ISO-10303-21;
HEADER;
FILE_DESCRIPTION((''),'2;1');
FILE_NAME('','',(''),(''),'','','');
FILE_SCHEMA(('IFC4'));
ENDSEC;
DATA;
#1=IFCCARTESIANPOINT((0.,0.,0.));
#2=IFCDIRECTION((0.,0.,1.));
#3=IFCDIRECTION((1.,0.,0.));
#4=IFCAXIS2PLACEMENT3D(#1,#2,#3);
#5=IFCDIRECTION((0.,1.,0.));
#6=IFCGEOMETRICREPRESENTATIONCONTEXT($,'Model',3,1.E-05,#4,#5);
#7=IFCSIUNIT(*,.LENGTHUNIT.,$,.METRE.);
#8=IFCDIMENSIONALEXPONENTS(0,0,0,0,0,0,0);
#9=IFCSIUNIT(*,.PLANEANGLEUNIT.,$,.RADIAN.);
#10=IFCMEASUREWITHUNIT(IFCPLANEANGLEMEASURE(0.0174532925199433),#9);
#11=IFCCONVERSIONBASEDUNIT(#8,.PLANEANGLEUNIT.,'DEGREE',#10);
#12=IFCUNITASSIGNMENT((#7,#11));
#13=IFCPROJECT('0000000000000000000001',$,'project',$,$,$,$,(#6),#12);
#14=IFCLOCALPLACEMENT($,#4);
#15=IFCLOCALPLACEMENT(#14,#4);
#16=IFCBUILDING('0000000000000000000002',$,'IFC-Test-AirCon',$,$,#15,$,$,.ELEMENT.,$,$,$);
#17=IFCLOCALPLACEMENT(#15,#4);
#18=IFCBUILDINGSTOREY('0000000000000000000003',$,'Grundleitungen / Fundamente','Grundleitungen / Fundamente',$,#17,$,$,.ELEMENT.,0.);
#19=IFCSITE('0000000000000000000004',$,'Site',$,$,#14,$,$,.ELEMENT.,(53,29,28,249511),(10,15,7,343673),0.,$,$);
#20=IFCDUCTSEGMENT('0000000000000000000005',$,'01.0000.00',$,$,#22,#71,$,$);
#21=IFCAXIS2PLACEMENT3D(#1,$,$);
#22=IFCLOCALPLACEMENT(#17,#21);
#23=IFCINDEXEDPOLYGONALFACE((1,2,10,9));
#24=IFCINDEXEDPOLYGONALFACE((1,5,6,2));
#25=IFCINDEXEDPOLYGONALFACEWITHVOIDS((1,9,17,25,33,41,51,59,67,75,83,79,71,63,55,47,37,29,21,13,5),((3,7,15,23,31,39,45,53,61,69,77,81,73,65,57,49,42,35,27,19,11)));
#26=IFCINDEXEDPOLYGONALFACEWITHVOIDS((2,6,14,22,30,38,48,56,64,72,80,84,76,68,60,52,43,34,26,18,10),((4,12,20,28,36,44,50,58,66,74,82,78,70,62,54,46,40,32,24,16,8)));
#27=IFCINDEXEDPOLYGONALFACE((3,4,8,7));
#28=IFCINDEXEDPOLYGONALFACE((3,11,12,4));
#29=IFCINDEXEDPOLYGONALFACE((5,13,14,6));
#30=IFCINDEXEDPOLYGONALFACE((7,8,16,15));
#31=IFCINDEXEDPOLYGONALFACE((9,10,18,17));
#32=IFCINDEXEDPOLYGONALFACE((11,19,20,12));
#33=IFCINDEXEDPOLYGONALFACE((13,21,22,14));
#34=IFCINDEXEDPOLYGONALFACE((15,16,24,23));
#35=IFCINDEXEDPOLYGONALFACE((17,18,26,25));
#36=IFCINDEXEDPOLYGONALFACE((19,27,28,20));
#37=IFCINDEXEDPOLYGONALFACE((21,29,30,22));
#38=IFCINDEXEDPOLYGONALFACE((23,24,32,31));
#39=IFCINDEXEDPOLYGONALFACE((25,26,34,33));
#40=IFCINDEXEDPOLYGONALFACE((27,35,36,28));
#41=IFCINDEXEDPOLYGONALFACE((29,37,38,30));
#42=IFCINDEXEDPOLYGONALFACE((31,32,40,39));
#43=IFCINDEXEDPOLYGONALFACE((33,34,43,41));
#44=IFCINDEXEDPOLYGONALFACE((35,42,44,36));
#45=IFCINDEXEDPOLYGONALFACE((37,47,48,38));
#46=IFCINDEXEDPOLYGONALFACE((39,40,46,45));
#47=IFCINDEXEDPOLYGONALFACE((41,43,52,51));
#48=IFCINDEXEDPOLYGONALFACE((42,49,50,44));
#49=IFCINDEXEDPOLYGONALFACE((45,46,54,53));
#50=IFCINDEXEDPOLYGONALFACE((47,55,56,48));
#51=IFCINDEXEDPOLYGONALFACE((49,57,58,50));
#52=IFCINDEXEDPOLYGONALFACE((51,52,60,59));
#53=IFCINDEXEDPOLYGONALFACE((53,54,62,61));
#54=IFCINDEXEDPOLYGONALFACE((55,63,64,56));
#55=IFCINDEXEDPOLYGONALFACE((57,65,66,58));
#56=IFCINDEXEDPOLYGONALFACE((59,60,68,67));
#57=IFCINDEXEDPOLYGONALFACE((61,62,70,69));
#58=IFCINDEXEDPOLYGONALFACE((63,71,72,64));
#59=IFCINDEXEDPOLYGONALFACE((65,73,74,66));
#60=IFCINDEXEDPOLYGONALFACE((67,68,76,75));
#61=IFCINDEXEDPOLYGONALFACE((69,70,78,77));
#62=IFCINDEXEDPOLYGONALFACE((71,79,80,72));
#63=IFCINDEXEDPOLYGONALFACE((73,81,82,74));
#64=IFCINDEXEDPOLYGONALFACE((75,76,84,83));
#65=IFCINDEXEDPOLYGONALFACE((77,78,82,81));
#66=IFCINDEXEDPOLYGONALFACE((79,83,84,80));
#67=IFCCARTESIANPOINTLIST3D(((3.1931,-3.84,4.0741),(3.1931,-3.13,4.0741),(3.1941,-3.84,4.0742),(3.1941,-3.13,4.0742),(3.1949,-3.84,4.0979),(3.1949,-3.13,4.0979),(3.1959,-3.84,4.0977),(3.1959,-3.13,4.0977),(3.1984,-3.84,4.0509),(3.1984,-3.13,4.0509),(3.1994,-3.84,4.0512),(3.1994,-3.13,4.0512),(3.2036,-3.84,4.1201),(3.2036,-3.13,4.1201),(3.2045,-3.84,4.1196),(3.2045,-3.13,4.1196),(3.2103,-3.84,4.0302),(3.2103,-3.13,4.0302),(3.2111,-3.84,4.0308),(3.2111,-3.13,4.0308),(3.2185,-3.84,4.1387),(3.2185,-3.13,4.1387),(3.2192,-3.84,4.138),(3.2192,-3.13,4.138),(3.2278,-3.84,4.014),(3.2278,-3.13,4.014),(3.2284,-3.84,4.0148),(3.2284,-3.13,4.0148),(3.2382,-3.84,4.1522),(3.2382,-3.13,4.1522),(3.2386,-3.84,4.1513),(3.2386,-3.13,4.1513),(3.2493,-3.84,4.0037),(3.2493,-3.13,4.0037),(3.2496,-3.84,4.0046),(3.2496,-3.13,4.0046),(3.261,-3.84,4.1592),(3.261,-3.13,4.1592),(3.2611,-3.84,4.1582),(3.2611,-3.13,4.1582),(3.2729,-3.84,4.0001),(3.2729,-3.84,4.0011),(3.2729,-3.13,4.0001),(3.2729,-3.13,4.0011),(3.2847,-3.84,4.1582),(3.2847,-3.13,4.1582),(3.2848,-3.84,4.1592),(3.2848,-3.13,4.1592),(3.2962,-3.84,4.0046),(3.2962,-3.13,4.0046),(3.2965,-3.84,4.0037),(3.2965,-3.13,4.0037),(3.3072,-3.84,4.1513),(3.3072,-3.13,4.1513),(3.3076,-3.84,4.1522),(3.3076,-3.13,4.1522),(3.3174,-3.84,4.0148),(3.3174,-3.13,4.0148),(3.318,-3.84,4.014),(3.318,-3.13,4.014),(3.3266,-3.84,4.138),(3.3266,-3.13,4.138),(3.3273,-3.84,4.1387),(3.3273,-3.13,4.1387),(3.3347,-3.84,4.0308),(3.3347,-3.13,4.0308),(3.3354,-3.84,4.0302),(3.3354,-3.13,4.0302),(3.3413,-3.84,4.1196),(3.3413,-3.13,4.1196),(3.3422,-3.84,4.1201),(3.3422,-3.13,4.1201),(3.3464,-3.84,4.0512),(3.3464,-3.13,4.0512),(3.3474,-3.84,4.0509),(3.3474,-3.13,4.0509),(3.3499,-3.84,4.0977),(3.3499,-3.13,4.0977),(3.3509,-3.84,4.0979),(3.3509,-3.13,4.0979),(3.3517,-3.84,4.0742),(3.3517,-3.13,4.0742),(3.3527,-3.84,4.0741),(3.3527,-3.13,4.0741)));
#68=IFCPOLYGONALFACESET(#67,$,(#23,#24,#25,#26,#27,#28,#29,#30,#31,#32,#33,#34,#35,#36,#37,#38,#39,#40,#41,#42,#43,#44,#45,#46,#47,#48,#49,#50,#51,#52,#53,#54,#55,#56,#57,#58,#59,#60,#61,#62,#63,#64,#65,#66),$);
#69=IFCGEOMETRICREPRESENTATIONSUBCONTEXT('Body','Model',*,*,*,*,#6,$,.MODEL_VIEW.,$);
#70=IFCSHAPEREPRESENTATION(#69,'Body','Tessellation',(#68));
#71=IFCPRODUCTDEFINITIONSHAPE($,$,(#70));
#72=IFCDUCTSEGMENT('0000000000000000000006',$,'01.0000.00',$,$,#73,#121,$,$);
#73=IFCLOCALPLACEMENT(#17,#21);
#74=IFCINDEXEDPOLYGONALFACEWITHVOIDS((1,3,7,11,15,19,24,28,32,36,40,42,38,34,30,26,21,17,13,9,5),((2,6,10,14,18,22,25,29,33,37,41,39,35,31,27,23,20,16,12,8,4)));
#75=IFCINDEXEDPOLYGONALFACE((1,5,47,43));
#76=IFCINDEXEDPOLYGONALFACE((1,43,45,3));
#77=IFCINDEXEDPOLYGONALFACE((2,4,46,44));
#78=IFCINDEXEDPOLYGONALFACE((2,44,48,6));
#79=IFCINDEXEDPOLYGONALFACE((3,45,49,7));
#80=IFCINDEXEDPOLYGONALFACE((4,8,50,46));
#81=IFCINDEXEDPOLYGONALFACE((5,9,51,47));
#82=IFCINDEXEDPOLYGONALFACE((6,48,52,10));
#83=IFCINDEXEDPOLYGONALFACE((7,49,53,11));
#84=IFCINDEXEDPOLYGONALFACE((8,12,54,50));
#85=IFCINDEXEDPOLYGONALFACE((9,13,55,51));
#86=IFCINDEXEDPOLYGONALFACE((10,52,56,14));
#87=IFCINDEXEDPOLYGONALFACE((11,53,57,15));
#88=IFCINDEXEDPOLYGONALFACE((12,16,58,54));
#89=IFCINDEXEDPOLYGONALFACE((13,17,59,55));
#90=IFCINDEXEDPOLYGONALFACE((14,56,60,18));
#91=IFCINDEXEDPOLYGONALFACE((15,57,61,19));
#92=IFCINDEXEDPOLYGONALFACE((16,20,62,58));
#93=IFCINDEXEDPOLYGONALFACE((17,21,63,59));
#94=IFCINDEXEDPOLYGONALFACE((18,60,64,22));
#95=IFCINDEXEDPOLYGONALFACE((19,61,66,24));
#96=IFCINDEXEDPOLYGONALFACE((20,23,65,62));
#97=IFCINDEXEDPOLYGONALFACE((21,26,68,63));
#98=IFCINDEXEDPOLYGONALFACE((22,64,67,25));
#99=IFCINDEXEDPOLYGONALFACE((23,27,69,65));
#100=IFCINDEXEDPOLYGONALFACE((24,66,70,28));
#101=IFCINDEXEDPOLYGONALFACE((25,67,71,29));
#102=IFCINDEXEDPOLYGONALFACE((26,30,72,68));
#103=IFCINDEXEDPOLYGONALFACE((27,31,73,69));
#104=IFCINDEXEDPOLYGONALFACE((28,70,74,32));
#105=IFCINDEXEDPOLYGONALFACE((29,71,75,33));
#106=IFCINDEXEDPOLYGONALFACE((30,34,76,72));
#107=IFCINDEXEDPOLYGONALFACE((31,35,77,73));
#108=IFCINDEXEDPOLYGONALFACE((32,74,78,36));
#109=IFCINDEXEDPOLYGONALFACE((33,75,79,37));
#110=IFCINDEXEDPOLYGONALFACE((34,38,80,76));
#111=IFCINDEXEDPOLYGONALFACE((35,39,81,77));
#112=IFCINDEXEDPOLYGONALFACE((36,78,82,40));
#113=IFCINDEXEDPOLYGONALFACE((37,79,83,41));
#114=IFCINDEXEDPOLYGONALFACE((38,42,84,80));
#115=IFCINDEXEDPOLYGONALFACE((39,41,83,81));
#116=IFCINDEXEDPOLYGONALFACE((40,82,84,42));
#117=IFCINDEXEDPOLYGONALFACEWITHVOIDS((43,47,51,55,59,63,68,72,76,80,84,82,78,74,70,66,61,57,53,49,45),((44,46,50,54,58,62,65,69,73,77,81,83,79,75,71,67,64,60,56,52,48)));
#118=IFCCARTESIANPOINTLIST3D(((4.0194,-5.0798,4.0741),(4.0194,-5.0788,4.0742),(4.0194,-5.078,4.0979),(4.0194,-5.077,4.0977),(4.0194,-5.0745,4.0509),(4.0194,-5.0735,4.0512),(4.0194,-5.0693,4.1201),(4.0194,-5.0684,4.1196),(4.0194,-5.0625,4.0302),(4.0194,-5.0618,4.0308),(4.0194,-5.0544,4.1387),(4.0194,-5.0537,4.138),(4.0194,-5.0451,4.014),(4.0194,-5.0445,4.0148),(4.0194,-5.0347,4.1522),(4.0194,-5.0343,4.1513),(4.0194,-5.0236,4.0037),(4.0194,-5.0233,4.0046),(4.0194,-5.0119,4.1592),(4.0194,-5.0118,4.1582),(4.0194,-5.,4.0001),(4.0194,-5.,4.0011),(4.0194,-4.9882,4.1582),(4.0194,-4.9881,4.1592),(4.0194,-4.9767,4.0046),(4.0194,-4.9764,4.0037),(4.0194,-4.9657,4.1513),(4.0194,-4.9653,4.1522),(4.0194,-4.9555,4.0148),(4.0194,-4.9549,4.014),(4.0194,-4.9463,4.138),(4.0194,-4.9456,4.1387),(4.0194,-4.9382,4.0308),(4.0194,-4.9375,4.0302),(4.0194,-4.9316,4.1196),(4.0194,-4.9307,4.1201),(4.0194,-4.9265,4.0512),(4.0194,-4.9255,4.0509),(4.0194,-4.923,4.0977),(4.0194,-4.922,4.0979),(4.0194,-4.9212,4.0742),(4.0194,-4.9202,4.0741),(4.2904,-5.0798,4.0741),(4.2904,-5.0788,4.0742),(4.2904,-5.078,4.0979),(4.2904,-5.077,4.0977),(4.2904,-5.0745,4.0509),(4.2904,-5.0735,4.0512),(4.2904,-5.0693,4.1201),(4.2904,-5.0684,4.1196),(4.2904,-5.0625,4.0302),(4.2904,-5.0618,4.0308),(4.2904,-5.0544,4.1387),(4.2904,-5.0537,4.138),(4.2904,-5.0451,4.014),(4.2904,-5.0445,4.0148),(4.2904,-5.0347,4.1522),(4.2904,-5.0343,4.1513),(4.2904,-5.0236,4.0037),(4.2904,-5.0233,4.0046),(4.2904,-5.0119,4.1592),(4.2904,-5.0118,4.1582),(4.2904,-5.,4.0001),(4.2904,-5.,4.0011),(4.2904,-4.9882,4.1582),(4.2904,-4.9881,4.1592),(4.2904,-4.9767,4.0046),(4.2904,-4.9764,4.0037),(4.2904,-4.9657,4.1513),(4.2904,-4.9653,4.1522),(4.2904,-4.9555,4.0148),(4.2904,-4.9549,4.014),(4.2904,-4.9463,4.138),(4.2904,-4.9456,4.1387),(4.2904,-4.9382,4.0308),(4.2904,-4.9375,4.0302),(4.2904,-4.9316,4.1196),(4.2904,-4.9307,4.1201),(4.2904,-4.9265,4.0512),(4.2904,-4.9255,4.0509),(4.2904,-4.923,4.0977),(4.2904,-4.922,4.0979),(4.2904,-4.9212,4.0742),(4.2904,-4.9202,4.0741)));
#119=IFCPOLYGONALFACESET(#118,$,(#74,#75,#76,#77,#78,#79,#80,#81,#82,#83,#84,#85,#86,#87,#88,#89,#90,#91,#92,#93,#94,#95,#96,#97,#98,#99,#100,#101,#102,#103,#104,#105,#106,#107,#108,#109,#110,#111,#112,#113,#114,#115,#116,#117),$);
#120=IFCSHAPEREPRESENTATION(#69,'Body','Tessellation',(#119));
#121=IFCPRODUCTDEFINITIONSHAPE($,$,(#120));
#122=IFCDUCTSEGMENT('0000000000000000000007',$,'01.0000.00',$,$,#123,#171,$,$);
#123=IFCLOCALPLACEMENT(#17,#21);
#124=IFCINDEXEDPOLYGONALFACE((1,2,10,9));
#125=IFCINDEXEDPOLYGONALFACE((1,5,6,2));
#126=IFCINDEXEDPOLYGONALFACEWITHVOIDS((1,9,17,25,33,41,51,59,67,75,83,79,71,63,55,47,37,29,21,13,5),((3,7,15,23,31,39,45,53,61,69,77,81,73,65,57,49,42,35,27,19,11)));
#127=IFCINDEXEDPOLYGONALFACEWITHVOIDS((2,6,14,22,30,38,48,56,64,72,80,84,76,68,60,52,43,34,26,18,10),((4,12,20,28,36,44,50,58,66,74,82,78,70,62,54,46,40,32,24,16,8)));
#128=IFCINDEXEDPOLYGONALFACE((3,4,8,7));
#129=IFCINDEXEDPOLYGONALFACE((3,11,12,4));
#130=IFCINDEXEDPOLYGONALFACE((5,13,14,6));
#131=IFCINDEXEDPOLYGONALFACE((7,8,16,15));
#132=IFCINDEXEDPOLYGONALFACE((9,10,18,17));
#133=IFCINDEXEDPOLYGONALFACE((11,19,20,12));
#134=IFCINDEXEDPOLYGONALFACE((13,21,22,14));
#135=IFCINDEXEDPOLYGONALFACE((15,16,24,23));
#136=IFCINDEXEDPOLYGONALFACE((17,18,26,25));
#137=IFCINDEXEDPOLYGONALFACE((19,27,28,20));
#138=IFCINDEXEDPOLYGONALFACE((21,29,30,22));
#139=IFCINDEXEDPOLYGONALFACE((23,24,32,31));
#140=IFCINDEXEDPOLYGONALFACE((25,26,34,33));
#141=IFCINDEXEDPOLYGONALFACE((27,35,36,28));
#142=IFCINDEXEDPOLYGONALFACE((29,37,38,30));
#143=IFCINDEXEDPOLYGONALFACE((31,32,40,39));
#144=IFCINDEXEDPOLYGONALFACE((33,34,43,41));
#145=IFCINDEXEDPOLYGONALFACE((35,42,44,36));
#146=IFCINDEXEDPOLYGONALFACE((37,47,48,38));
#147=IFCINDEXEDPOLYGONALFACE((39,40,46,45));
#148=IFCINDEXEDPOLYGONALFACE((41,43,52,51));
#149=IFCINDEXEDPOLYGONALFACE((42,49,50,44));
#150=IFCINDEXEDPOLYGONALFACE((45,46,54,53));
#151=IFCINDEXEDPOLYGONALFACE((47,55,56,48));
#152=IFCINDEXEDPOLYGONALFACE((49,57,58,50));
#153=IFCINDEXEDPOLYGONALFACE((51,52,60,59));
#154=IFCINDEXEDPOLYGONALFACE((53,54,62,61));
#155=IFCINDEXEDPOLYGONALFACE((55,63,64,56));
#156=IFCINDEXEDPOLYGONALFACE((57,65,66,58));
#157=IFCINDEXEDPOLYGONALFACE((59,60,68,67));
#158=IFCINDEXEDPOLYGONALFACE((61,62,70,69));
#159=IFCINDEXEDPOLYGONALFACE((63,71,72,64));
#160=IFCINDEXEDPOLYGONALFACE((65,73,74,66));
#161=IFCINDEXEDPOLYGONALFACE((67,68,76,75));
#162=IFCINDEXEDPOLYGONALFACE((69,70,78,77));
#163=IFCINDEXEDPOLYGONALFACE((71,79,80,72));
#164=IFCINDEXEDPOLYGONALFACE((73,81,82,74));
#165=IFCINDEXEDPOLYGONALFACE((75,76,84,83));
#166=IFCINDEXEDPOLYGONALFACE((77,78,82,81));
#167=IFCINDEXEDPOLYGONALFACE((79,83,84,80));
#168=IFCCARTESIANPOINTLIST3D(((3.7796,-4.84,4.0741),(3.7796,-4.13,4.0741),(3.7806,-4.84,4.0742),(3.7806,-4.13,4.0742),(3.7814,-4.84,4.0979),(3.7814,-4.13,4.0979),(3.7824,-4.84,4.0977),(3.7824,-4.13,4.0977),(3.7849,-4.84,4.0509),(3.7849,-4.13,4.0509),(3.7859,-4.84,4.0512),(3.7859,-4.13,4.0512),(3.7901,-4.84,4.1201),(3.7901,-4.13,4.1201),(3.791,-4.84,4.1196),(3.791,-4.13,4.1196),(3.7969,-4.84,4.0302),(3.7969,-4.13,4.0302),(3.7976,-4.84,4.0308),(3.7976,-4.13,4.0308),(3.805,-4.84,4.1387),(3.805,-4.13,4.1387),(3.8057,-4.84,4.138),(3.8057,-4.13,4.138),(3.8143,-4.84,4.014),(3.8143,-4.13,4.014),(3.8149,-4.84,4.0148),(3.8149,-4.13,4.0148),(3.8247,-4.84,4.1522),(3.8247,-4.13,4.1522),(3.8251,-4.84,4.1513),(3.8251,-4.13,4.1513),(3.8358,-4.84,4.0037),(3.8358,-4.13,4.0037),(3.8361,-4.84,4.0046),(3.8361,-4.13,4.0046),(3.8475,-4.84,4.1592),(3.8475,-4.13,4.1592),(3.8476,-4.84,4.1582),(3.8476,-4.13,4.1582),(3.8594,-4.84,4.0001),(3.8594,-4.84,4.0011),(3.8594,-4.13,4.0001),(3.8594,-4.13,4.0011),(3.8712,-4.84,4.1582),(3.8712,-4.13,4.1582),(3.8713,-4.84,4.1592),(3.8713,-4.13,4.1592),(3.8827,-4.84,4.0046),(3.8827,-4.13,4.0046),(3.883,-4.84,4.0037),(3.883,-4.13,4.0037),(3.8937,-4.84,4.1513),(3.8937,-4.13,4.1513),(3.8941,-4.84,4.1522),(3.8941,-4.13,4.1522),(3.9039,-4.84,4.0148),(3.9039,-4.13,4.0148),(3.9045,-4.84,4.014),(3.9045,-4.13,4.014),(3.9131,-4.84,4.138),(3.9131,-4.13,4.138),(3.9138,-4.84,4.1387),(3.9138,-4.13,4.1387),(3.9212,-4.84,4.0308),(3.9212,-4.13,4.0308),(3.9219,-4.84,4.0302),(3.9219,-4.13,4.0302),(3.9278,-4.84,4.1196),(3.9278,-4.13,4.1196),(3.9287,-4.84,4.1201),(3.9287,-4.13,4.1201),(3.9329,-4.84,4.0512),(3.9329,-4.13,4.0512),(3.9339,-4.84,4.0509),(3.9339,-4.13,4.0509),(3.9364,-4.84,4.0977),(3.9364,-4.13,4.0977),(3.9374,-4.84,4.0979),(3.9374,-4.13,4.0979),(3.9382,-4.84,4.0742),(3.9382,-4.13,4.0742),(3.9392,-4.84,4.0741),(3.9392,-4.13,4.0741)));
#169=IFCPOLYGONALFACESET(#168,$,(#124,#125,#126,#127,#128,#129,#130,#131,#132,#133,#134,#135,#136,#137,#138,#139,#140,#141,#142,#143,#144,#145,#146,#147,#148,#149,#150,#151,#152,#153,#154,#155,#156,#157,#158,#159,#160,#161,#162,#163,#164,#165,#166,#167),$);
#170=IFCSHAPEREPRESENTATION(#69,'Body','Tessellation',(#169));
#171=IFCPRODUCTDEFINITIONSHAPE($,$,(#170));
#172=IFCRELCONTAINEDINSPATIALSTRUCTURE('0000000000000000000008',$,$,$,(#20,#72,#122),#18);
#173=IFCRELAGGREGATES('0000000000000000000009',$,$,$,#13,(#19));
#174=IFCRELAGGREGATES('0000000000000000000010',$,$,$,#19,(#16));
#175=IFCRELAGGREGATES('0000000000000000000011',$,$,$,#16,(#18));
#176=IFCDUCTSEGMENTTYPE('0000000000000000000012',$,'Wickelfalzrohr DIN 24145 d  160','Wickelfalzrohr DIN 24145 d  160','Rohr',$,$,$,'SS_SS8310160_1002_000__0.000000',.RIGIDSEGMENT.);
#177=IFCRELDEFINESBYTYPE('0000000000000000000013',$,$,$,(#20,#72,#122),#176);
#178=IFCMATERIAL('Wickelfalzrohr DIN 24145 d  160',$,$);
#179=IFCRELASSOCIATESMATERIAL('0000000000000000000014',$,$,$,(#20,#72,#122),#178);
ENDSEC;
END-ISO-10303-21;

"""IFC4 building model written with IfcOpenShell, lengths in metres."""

from ifc_helpers import new_model, entity, si_unit, converted_unit, direction, frame, origin_with_axes, origin_2d_with_axis, place, context, subcontext, project, spatial, hollow_circle, extrude, material, type_object, element, save


model = new_model("IFC4")

# Units and contexts
model_context = context("Model", 3, precision=1e-05, world=origin_with_axes(), true_north=direction((0.0, 1.0, 0.0)))
body_context = subcontext(model_context, "Body", "Model", "MODEL_VIEW")
ifc_project = project(units=[si_unit("LENGTHUNIT", "METRE"), converted_unit("PLANEANGLEUNIT", "DEGREE", entity("IfcPlaneAngleMeasure", 0.0174532925199433), si_unit("PLANEANGLEUNIT", "RADIAN"), dimensions=[0, 0, 0, 0, 0, 0, 0])], contexts=[model_context])

# Site, building, storey
site_placement = place(None, origin_with_axes())
site = spatial("IfcSite", under=ifc_project, at=site_placement, Name="Site", CompositionType="ELEMENT", RefLatitude=(53, 29, 28, 249511), RefLongitude=(10, 15, 7, 343673), RefElevation=0.0)
building_placement = place(site_placement, origin_with_axes())
building = spatial("IfcBuilding", under=site, at=building_placement, Name="IFC-Test-AirCon", CompositionType="ELEMENT")
storey_placement = place(building_placement, origin_with_axes())
storey = spatial("IfcBuildingStorey", under=building, at=storey_placement, Name="Grundleitungen / Fundamente", Description="Grundleitungen / Fundamente", CompositionType="ELEMENT", Elevation=0.0)

# Duct segments
ifc_material_1 = material(Name="Wickelfalzrohr DIN 24145 d  160")
duct_segment_type_1 = type_object("IfcDuctSegmentType", Name="Wickelfalzrohr DIN 24145 d  160", Description="Wickelfalzrohr DIN 24145 d  160", ApplicableOccurrence="Rohr", ElementType="SS_SS8310160_1002_000__0.000000", PredefinedType="RIGIDSEGMENT")
duct_segment_1_placement = place(storey_placement, frame((3.2729, -3.84, 4.0801), z_axis=(0.0, 0.0, 1.0), x_axis=(0.0, 1.0, 0.0)))
element("IfcDuctSegment", 1, at=duct_segment_1_placement, inside=storey, type_object=duct_segment_type_1, material=ifc_material_1, Name="01.0000.00", context=body_context, shape_type="SweptSolid", body=[
    extrude(hollow_circle(Radius=0.08, WallThickness=0.001, at=origin_2d_with_axis()), frame((0.0, 0.0, 0.0), z_axis=(1.0, 0.0, 0.0), x_axis=(0.0, 0.0, -1.0)), (0.0, 0.0, 1.0), 0.71),
])
duct_segment_2_placement = place(storey_placement, frame((4.2904, -5.0, 4.0801), z_axis=(0.0, 0.0, 1.0), x_axis=(-1.0, 0.0, 0.0)))
element("IfcDuctSegment", 2, at=duct_segment_2_placement, inside=storey, type_object=duct_segment_type_1, material=ifc_material_1, Name="01.0000.00", context=body_context, shape_type="SweptSolid", body=[
    extrude(hollow_circle(Radius=0.08, WallThickness=0.001, at=origin_2d_with_axis()), frame((0.0, 0.0, 0.0), z_axis=(1.0, 0.0, 0.0), x_axis=(0.0, 0.0, -1.0)), (0.0, 0.0, 1.0), 0.271),
])
for number, where, z_axis, x_axis, name in (
    (3, (3.8594, -4.84, 4.0801), (0.0, 0.0, 1.0), (0.0, 1.0, 0.0), "01.0000.00"),
):
    element("IfcDuctSegment", number, at=place(storey_placement, frame(where, z_axis=z_axis, x_axis=x_axis)), inside=storey, type_object=duct_segment_type_1, material=ifc_material_1, Name=name, context=body_context, shape_type="SweptSolid", body=[
        extrude(hollow_circle(Radius=0.08, WallThickness=0.001, at=origin_2d_with_axis()), frame((0.0, 0.0, 0.0), z_axis=(1.0, 0.0, 0.0), x_axis=(0.0, 0.0, -1.0)), (0.0, 0.0, 1.0), 0.71),
    ])

save(model, "model.ifc")
